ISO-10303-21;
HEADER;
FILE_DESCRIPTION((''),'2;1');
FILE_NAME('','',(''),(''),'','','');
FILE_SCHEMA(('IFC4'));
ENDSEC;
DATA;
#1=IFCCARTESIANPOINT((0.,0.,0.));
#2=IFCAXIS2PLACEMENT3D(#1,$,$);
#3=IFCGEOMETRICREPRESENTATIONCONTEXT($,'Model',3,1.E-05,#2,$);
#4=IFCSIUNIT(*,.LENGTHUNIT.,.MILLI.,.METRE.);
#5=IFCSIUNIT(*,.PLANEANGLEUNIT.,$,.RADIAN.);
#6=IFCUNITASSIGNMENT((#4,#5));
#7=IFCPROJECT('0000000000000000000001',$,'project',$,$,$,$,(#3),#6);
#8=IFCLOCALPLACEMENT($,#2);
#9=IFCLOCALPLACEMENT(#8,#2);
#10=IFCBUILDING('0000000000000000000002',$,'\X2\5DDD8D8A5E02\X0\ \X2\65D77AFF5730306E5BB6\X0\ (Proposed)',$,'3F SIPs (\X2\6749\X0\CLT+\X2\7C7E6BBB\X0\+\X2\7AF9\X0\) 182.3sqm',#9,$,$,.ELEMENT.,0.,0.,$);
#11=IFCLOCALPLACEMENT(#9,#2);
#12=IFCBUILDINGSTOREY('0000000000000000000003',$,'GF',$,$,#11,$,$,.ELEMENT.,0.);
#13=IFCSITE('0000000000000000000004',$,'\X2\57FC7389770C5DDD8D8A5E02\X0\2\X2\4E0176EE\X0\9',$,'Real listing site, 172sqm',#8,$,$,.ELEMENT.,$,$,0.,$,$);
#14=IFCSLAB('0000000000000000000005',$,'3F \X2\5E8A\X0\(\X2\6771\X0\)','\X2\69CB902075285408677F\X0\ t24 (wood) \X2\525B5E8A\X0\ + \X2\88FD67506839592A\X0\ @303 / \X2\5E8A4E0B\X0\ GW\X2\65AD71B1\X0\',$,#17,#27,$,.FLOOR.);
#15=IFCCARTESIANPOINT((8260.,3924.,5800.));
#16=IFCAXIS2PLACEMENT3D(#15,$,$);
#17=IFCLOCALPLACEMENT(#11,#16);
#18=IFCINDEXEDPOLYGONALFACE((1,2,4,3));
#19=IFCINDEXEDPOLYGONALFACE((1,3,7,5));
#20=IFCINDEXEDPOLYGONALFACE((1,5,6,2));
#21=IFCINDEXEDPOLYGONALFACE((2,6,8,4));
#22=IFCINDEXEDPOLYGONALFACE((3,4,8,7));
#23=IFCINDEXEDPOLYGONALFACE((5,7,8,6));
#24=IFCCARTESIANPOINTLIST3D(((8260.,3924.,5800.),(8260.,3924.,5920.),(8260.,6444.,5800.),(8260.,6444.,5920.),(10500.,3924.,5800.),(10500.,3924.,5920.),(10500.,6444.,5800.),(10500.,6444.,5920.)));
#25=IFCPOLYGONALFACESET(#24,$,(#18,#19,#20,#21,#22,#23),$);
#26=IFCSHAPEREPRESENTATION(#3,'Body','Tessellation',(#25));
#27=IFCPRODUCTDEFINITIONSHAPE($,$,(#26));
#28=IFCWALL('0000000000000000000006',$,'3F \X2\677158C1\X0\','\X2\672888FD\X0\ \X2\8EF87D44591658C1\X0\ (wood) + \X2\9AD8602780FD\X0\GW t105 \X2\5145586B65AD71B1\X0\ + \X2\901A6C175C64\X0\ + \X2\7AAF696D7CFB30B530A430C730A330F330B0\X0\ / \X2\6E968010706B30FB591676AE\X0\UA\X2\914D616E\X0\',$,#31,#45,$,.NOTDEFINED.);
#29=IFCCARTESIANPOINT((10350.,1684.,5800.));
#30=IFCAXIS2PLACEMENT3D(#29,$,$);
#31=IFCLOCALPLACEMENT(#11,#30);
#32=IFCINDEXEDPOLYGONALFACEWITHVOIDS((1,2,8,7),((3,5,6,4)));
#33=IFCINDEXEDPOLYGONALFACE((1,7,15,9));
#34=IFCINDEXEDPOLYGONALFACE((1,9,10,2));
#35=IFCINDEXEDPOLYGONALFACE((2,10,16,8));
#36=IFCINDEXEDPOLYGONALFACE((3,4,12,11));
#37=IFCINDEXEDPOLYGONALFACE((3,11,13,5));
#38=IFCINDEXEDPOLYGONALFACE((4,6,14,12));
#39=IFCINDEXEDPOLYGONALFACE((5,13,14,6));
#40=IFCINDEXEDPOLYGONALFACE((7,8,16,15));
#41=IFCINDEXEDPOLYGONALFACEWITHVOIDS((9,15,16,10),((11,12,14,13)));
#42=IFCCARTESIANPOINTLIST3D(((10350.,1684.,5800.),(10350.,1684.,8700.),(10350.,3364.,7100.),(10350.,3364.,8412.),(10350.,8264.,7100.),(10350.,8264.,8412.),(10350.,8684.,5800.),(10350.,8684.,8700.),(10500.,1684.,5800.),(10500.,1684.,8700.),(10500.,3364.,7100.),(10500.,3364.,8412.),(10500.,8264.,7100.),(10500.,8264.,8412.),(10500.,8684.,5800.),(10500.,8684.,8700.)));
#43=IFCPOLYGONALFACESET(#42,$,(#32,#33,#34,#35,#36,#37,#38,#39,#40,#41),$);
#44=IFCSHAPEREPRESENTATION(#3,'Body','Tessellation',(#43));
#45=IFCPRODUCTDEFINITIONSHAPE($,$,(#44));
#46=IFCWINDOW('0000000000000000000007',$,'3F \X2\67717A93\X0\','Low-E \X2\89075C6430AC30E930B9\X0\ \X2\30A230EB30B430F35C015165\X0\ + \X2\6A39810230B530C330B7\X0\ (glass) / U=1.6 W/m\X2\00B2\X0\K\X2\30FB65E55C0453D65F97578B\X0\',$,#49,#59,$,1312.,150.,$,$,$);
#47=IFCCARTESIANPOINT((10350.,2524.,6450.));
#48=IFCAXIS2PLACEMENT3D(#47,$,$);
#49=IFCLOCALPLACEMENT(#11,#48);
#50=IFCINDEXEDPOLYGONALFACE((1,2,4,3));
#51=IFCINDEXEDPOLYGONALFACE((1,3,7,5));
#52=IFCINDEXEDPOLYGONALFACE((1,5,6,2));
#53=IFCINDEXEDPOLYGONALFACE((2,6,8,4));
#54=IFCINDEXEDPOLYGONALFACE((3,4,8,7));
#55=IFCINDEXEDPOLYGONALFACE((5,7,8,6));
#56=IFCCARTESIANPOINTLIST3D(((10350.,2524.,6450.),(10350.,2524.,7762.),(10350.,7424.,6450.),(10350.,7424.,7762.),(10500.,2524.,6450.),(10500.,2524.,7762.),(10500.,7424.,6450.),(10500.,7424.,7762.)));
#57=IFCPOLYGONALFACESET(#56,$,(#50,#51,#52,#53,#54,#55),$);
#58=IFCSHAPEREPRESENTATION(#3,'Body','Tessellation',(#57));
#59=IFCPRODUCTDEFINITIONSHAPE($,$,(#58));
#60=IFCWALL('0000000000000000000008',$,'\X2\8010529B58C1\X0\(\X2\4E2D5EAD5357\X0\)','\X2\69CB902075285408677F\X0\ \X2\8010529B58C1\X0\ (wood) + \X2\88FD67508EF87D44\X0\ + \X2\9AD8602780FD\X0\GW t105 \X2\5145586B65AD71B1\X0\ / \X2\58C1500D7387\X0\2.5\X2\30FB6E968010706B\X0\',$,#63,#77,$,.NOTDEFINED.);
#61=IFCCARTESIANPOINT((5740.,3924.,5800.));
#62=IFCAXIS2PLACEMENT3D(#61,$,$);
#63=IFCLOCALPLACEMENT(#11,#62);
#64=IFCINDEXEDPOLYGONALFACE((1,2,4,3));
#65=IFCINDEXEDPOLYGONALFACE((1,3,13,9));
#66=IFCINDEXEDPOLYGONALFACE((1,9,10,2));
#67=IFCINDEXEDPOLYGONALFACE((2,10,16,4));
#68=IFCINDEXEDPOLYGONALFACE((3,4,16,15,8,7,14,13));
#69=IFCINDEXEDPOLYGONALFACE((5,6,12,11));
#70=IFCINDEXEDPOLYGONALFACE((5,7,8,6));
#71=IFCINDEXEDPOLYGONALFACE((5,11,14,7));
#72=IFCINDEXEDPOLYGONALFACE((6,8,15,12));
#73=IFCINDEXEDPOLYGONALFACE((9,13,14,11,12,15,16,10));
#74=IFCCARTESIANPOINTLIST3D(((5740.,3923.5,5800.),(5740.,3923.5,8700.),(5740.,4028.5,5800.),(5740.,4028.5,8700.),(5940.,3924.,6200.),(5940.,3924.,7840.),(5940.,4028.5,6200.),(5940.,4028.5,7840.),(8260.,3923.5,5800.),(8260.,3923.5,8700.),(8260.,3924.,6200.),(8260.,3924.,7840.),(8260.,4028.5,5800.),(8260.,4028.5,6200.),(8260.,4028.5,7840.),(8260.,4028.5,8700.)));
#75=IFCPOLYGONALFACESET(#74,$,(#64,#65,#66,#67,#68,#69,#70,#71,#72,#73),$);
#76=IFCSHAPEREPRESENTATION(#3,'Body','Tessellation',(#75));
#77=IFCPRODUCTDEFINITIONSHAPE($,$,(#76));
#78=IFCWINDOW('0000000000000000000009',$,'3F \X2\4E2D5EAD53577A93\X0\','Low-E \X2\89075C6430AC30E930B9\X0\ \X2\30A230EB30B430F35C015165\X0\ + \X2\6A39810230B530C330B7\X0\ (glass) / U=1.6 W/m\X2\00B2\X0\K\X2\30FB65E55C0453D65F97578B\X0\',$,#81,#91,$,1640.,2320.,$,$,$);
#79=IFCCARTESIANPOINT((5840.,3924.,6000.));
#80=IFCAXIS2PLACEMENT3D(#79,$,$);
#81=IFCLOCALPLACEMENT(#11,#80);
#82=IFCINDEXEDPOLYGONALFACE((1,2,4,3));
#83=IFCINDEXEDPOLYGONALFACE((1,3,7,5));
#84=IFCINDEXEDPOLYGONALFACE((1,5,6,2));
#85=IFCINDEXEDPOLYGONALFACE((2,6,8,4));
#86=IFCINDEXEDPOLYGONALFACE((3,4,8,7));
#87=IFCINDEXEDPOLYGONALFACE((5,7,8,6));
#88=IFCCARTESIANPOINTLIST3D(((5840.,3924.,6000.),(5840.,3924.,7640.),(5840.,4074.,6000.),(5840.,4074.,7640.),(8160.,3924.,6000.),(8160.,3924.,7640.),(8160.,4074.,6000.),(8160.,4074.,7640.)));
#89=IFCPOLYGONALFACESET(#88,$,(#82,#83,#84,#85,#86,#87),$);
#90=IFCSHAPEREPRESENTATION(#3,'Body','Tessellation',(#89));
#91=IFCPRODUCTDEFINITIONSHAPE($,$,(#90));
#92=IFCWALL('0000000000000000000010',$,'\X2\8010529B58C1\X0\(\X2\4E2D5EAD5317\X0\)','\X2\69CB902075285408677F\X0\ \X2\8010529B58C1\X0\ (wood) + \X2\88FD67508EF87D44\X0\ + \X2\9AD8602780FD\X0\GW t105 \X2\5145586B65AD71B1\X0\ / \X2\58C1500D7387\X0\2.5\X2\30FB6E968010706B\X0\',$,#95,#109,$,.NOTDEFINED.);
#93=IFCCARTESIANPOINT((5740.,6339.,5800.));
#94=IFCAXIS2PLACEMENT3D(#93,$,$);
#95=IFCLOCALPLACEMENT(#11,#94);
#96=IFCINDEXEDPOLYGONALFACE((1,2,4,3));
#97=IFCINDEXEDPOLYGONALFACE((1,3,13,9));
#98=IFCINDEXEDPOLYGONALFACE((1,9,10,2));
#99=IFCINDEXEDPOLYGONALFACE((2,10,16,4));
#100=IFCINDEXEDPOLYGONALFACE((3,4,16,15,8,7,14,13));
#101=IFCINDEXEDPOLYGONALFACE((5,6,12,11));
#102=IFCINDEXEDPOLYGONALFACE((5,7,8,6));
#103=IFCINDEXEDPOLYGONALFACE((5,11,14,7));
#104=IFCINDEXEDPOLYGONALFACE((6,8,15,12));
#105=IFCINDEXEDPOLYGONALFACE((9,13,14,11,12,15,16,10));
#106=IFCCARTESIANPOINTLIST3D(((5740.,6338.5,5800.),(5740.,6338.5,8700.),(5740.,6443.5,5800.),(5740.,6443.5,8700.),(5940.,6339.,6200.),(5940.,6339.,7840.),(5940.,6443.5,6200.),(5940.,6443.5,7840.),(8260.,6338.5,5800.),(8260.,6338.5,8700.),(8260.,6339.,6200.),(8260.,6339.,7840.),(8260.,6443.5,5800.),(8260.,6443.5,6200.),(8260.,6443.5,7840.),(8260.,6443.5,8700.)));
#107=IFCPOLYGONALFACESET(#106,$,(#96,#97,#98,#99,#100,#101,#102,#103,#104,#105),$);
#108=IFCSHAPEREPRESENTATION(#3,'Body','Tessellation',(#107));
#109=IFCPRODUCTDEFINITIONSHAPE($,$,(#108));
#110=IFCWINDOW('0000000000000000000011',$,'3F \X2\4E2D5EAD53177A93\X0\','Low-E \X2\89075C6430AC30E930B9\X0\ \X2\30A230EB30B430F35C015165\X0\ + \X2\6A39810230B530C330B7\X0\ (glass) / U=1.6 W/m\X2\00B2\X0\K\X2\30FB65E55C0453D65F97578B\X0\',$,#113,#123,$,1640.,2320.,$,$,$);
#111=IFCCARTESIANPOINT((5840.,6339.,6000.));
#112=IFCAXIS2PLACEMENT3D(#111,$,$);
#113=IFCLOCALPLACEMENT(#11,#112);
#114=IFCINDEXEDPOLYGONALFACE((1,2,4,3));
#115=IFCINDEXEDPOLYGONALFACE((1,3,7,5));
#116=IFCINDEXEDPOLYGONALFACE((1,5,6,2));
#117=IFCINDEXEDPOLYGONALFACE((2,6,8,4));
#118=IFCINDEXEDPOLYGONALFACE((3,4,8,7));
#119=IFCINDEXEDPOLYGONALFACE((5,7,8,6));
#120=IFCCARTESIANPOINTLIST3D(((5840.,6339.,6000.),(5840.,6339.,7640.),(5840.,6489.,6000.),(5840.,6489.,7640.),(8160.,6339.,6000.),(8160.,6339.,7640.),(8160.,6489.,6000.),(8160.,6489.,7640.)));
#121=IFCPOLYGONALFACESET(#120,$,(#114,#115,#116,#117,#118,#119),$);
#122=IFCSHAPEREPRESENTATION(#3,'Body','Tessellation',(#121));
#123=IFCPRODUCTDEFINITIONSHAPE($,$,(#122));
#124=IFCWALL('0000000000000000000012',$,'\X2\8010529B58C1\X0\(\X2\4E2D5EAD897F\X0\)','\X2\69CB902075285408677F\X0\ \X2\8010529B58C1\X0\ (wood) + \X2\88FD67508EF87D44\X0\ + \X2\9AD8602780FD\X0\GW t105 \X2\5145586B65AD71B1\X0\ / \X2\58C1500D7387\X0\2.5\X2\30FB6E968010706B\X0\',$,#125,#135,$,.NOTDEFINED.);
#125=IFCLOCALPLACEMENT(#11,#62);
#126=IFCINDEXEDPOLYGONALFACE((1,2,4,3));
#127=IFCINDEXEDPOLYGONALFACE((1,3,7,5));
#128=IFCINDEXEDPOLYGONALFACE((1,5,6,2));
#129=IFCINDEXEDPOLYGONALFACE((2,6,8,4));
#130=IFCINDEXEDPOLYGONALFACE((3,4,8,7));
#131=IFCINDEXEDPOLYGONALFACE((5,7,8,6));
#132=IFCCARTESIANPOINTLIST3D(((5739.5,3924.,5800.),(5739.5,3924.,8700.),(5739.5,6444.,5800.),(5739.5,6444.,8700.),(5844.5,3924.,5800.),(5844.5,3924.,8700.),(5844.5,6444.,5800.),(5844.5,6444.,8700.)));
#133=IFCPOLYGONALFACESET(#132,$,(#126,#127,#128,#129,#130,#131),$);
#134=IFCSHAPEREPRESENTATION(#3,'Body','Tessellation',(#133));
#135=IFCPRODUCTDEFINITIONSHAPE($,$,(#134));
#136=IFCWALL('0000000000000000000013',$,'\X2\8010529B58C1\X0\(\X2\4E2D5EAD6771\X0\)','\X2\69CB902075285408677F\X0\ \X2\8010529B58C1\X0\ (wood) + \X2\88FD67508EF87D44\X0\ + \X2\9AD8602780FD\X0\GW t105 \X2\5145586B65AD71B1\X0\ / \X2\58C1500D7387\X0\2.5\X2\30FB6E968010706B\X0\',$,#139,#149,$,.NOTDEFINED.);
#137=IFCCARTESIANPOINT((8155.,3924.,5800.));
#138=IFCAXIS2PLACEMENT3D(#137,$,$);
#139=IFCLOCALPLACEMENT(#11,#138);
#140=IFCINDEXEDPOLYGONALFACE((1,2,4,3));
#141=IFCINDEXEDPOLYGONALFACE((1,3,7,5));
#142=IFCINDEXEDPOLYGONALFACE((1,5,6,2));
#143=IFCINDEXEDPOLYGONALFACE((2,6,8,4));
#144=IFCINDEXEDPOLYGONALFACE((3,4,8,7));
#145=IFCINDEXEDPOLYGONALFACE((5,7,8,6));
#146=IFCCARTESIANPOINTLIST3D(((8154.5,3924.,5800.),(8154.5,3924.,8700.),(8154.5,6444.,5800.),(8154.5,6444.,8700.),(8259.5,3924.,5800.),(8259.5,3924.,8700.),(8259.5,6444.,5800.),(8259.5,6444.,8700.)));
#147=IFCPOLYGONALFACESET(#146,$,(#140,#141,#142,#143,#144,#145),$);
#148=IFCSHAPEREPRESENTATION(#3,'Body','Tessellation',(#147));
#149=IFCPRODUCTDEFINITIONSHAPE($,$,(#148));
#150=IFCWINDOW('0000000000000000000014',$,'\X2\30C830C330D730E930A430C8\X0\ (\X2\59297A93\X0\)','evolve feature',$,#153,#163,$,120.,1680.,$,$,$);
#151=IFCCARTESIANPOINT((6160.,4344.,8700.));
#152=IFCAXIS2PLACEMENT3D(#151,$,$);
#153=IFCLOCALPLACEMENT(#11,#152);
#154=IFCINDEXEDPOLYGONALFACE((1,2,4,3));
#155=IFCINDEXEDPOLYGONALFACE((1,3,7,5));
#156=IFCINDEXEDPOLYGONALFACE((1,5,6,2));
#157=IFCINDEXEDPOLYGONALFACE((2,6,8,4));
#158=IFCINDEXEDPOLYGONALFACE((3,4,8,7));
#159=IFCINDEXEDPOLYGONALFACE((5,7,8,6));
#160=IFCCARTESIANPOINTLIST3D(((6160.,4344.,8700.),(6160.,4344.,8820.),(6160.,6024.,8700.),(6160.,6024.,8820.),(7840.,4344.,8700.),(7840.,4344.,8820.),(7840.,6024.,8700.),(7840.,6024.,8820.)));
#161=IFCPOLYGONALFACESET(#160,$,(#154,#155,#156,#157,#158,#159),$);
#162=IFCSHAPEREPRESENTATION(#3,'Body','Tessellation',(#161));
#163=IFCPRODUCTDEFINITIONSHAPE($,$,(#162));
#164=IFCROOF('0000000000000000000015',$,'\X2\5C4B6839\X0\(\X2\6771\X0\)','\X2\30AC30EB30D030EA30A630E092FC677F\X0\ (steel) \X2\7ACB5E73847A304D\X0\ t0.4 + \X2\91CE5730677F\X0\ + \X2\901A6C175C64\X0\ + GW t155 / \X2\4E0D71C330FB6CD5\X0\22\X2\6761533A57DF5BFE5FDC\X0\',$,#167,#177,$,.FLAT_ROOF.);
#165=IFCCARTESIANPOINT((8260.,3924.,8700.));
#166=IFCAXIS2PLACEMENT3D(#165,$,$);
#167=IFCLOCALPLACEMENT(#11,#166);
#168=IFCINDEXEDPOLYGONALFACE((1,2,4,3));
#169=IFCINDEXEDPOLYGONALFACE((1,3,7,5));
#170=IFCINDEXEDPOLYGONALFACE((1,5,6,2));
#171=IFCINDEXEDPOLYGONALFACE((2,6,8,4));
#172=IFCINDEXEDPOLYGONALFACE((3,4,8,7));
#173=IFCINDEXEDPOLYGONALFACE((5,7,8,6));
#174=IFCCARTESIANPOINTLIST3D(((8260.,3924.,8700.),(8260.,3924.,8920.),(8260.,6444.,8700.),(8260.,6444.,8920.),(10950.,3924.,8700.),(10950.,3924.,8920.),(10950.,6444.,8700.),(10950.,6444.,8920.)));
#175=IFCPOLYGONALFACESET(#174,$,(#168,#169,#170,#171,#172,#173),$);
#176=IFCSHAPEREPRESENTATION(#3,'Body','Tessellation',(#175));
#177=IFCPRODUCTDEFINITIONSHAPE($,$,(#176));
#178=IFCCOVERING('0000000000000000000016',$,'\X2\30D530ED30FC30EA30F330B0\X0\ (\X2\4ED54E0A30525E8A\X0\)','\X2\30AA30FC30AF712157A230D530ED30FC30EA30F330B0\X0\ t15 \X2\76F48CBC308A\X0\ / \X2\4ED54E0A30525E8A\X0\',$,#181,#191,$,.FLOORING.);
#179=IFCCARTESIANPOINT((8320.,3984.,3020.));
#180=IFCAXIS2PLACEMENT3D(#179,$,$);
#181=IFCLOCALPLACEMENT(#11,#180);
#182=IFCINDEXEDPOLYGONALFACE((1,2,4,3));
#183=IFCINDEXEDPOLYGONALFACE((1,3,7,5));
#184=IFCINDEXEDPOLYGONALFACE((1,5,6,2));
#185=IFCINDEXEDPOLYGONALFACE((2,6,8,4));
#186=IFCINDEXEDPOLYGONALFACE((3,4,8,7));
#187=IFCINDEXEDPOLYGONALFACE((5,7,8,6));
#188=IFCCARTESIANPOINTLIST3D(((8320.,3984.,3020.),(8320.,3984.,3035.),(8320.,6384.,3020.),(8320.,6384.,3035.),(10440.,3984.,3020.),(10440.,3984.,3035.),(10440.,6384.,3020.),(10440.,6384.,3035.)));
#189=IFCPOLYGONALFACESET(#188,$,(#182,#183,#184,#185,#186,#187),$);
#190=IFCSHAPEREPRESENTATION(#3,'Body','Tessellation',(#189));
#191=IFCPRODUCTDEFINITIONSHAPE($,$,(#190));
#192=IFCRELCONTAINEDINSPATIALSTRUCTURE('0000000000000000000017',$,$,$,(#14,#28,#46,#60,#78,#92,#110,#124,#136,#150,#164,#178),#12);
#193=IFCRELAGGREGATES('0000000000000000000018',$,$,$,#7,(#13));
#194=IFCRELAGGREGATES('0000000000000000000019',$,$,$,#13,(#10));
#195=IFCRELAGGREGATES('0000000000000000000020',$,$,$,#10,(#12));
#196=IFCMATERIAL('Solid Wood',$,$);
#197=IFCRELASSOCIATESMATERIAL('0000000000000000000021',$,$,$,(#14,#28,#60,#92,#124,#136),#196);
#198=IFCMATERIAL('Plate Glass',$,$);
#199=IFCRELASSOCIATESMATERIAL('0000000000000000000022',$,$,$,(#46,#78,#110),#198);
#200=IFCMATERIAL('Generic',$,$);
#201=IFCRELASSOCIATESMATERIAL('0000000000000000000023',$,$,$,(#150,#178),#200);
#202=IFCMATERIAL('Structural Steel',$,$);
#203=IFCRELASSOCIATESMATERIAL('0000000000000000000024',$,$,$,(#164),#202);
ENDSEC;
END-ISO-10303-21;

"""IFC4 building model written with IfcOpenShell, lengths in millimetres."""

from ifc_helpers import new_model, si_unit, frame, frame_2d, origin, place, context, project, spatial, rectangle, extrude, material, element, fill, save


model = new_model("IFC4")

# Units and contexts
model_context = context("Model", 3, precision=1e-05, world=origin())
ifc_project = project(units=[si_unit("LENGTHUNIT", "METRE", prefix="MILLI"), si_unit("PLANEANGLEUNIT", "RADIAN")], contexts=[model_context])

# Site, building, storey
site_placement = place(None, origin())
site = spatial("IfcSite", under=ifc_project, at=site_placement, Name="埼玉県川越市2丁目9", ObjectType="Real listing site, 172sqm", CompositionType="ELEMENT", RefElevation=0.0)
building_placement = place(site_placement, origin())
building = spatial("IfcBuilding", under=site, at=building_placement, Name="川越市 旗竿地の家 (Proposed)", ObjectType="3F SIPs (杉CLT+籾殻+竹) 182.3sqm", CompositionType="ELEMENT", ElevationOfRefHeight=0.0, ElevationOfTerrain=0.0)
storey_placement = place(building_placement, origin())
storey = spatial("IfcBuildingStorey", under=building, at=storey_placement, Name="GF", CompositionType="ELEMENT", Elevation=0.0)

# Slab
ifc_material_1 = material(Name="Solid Wood")
slab_placement = place(storey_placement, frame((8260.0, 3924.0, 5800.0)))
element("IfcSlab", 1, at=slab_placement, inside=storey, material=ifc_material_1, Name="3F 床(東)", Description="構造用合板 t24 (wood) 剛床 + 製材根太 @303 / 床下 GW断熱", PredefinedType="FLOOR", context=model_context, shape_type="SweptSolid", body=[
    extrude(rectangle(XDim=2240.0, YDim=2520.0, at=frame_2d((1120.0, 1260.0))), frame((8260.0, 3924.0, 5800.0)), (0.0, 0.0, 1.0), 120.0),
])

# Walls, openings, windows
wall_1_placement = place(storey_placement, frame((10350.0, 1684.0, 5800.0)))
wall_1 = element("IfcWall", 2, at=wall_1_placement, inside=storey, material=ifc_material_1, Name="3F 東壁", Description="木製 軸組外壁 (wood) + 高性能GW t105 充填断熱 + 通気層 + 窯業系サイディング / 準耐火・外皮UA配慮", PredefinedType="NOTDEFINED", context=model_context, shape_type="SweptSolid", body=[
    extrude(rectangle(XDim=150.0, YDim=7000.0, at=frame_2d((75.0, 3500.0))), frame((10350.0, 1684.0, 5800.0)), (0.0, 0.0, 1.0), 2900.0),
])
opening_1_placement = place(storey_placement, frame((10350.0, 2524.0, 6450.0)))
opening_1 = element("IfcOpeningElement", 3, at=opening_1_placement, cuts=wall_1, PredefinedType="NOTDEFINED", context=model_context, shape_type="SweptSolid", body=[
    extrude(rectangle(XDim=150.0, YDim=4900.0, at=frame_2d((75.0, 2450.0))), frame((10350.0, 2524.0, 6450.0)), (0.0, 0.0, 1.0), 1312.0),
])
ifc_material_2 = material(Name="Plate Glass")
window_1_placement = place(storey_placement, frame((10350.0, 2524.0, 6450.0)))
window_1 = element("IfcWindow", 4, at=window_1_placement, inside=storey, material=ifc_material_2, Name="3F 東窓", Description="Low-E 複層ガラス アルゴン封入 + 樹脂サッシ (glass) / U=1.6 W/m²K・日射取得型", OverallHeight=1312.0, OverallWidth=150.0, context=model_context, shape_type="SweptSolid", body=[
    extrude(rectangle(XDim=150.0, YDim=4900.0, at=frame_2d((75.0, 2450.0))), frame((10350.0, 2524.0, 6450.0)), (0.0, 0.0, 1.0), 1312.0),
])
fill(opening_1, window_1)
wall_2_placement = place(storey_placement, frame((5740.0, 3924.0, 5800.0)))
wall_2 = element("IfcWall", 5, at=wall_2_placement, inside=storey, material=ifc_material_1, Name="耐力壁(中庭南)", Description="構造用合板 耐力壁 (wood) + 製材軸組 + 高性能GW t105 充填断熱 / 壁倍率2.5・準耐火", PredefinedType="NOTDEFINED", context=model_context, shape_type="SweptSolid", body=[
    extrude(rectangle(XDim=2520.0, YDim=105.0, at=frame_2d((1260.0, 52.0))), frame((5740.0, 3924.0, 5800.0)), (0.0, 0.0, 1.0), 2900.0),
])
opening_2_placement = place(storey_placement, frame((5840.0, 3924.0, 6000.0)))
opening_2 = element("IfcOpeningElement", 6, at=opening_2_placement, cuts=wall_2, PredefinedType="NOTDEFINED", context=model_context, shape_type="SweptSolid", body=[
    extrude(rectangle(XDim=2320.0, YDim=150.0, at=frame_2d((1160.0, 75.0))), frame((5840.0, 3924.0, 6000.0)), (0.0, 0.0, 1.0), 1640.0),
])
window_2_placement = place(storey_placement, frame((5840.0, 3924.0, 6000.0)))
window_2 = element("IfcWindow", 7, at=window_2_placement, inside=storey, material=ifc_material_2, Name="3F 中庭南窓", Description="Low-E 複層ガラス アルゴン封入 + 樹脂サッシ (glass) / U=1.6 W/m²K・日射取得型", OverallHeight=1640.0, OverallWidth=2320.0, context=model_context, shape_type="SweptSolid", body=[
    extrude(rectangle(XDim=2320.0, YDim=150.0, at=frame_2d((1160.0, 75.0))), frame((5840.0, 3924.0, 6000.0)), (0.0, 0.0, 1.0), 1640.0),
])
fill(opening_2, window_2)
wall_3_placement = place(storey_placement, frame((5740.0, 6339.0, 5800.0)))
wall_3 = element("IfcWall", 8, at=wall_3_placement, inside=storey, material=ifc_material_1, Name="耐力壁(中庭北)", Description="構造用合板 耐力壁 (wood) + 製材軸組 + 高性能GW t105 充填断熱 / 壁倍率2.5・準耐火", PredefinedType="NOTDEFINED", context=model_context, shape_type="SweptSolid", body=[
    extrude(rectangle(XDim=2520.0, YDim=105.0, at=frame_2d((1260.0, 52.0))), frame((5740.0, 6339.0, 5800.0)), (0.0, 0.0, 1.0), 2900.0),
])
opening_3_placement = place(storey_placement, frame((5840.0, 6339.0, 6000.0)))
opening_3 = element("IfcOpeningElement", 9, at=opening_3_placement, cuts=wall_3, PredefinedType="NOTDEFINED", context=model_context, shape_type="SweptSolid", body=[
    extrude(rectangle(XDim=2320.0, YDim=150.0, at=frame_2d((1160.0, 75.0))), frame((5840.0, 6339.0, 6000.0)), (0.0, 0.0, 1.0), 1640.0),
])
window_3_placement = place(storey_placement, frame((5840.0, 6339.0, 6000.0)))
window_3 = element("IfcWindow", 10, at=window_3_placement, inside=storey, material=ifc_material_2, Name="3F 中庭北窓", Description="Low-E 複層ガラス アルゴン封入 + 樹脂サッシ (glass) / U=1.6 W/m²K・日射取得型", OverallHeight=1640.0, OverallWidth=2320.0, context=model_context, shape_type="SweptSolid", body=[
    extrude(rectangle(XDim=2320.0, YDim=150.0, at=frame_2d((1160.0, 75.0))), frame((5840.0, 6339.0, 6000.0)), (0.0, 0.0, 1.0), 1640.0),
])
fill(opening_3, window_3)

# Walls
wall_4_placement = place(storey_placement, frame((5740.0, 3924.0, 5800.0)))
element("IfcWall", 11, at=wall_4_placement, inside=storey, material=ifc_material_1, Name="耐力壁(中庭西)", Description="構造用合板 耐力壁 (wood) + 製材軸組 + 高性能GW t105 充填断熱 / 壁倍率2.5・準耐火", PredefinedType="NOTDEFINED", context=model_context, shape_type="SweptSolid", body=[
    extrude(rectangle(XDim=105.0, YDim=2520.0, at=frame_2d((52.0, 1260.0))), frame((5740.0, 3924.0, 5800.0)), (0.0, 0.0, 1.0), 2900.0),
])
wall_5_placement = place(storey_placement, frame((8155.0, 3924.0, 5800.0)))
element("IfcWall", 12, at=wall_5_placement, inside=storey, material=ifc_material_1, Name="耐力壁(中庭東)", Description="構造用合板 耐力壁 (wood) + 製材軸組 + 高性能GW t105 充填断熱 / 壁倍率2.5・準耐火", PredefinedType="NOTDEFINED", context=model_context, shape_type="SweptSolid", body=[
    extrude(rectangle(XDim=105.0, YDim=2520.0, at=frame_2d((52.0, 1260.0))), frame((8155.0, 3924.0, 5800.0)), (0.0, 0.0, 1.0), 2900.0),
])

# Window
ifc_material_3 = material(Name="Generic")
window_4_placement = place(storey_placement, frame((6160.0, 4344.0, 8700.0)))
element("IfcWindow", 13, at=window_4_placement, inside=storey, material=ifc_material_3, Name="トップライト (天窓)", Description="evolve feature", OverallHeight=120.0, OverallWidth=1680.0, context=model_context, shape_type="SweptSolid", body=[
    extrude(rectangle(XDim=1680.0, YDim=1680.0, at=frame_2d((840.0, 840.0))), frame((6160.0, 4344.0, 8700.0)), (0.0, 0.0, 1.0), 120.0),
])

# Roof
ifc_material_4 = material(Name="Structural Steel")
for number, where, name in (
    (14, (8260.0, 3924.0, 8700.0), "屋根(東)"),
):
    element("IfcRoof", number, at=place(storey_placement, frame(where)), inside=storey, material=ifc_material_4, Name=name, Description="ガルバリウム鋼板 (steel) 立平葺き t0.4 + 野地板 + 通気層 + GW t155 / 不燃・法22条区域対応", PredefinedType="FLAT_ROOF", context=model_context, shape_type="SweptSolid", body=[
        extrude(rectangle(XDim=2690.0, YDim=2520.0, at=frame_2d((1345.0, 1260.0))), frame((8260.0, 3924.0, 8700.0)), (0.0, 0.0, 1.0), 220.0),
    ])

# Covering
covering_1_placement = place(storey_placement, frame((8320.0, 3984.0, 3020.0)))
element("IfcCovering", 15, at=covering_1_placement, inside=storey, material=ifc_material_3, Name="フローリング (仕上げ床)", Description="オーク無垢フローリング t15 直貼り / 仕上げ床", PredefinedType="FLOORING", context=model_context, shape_type="SweptSolid", body=[
    extrude(rectangle(XDim=2120.0, YDim=2400.0, at=frame_2d((1060.0, 1200.0))), frame((8320.0, 3984.0, 3020.0)), (0.0, 0.0, 1.0), 15.0),
])

save(model, "model.ifc")
